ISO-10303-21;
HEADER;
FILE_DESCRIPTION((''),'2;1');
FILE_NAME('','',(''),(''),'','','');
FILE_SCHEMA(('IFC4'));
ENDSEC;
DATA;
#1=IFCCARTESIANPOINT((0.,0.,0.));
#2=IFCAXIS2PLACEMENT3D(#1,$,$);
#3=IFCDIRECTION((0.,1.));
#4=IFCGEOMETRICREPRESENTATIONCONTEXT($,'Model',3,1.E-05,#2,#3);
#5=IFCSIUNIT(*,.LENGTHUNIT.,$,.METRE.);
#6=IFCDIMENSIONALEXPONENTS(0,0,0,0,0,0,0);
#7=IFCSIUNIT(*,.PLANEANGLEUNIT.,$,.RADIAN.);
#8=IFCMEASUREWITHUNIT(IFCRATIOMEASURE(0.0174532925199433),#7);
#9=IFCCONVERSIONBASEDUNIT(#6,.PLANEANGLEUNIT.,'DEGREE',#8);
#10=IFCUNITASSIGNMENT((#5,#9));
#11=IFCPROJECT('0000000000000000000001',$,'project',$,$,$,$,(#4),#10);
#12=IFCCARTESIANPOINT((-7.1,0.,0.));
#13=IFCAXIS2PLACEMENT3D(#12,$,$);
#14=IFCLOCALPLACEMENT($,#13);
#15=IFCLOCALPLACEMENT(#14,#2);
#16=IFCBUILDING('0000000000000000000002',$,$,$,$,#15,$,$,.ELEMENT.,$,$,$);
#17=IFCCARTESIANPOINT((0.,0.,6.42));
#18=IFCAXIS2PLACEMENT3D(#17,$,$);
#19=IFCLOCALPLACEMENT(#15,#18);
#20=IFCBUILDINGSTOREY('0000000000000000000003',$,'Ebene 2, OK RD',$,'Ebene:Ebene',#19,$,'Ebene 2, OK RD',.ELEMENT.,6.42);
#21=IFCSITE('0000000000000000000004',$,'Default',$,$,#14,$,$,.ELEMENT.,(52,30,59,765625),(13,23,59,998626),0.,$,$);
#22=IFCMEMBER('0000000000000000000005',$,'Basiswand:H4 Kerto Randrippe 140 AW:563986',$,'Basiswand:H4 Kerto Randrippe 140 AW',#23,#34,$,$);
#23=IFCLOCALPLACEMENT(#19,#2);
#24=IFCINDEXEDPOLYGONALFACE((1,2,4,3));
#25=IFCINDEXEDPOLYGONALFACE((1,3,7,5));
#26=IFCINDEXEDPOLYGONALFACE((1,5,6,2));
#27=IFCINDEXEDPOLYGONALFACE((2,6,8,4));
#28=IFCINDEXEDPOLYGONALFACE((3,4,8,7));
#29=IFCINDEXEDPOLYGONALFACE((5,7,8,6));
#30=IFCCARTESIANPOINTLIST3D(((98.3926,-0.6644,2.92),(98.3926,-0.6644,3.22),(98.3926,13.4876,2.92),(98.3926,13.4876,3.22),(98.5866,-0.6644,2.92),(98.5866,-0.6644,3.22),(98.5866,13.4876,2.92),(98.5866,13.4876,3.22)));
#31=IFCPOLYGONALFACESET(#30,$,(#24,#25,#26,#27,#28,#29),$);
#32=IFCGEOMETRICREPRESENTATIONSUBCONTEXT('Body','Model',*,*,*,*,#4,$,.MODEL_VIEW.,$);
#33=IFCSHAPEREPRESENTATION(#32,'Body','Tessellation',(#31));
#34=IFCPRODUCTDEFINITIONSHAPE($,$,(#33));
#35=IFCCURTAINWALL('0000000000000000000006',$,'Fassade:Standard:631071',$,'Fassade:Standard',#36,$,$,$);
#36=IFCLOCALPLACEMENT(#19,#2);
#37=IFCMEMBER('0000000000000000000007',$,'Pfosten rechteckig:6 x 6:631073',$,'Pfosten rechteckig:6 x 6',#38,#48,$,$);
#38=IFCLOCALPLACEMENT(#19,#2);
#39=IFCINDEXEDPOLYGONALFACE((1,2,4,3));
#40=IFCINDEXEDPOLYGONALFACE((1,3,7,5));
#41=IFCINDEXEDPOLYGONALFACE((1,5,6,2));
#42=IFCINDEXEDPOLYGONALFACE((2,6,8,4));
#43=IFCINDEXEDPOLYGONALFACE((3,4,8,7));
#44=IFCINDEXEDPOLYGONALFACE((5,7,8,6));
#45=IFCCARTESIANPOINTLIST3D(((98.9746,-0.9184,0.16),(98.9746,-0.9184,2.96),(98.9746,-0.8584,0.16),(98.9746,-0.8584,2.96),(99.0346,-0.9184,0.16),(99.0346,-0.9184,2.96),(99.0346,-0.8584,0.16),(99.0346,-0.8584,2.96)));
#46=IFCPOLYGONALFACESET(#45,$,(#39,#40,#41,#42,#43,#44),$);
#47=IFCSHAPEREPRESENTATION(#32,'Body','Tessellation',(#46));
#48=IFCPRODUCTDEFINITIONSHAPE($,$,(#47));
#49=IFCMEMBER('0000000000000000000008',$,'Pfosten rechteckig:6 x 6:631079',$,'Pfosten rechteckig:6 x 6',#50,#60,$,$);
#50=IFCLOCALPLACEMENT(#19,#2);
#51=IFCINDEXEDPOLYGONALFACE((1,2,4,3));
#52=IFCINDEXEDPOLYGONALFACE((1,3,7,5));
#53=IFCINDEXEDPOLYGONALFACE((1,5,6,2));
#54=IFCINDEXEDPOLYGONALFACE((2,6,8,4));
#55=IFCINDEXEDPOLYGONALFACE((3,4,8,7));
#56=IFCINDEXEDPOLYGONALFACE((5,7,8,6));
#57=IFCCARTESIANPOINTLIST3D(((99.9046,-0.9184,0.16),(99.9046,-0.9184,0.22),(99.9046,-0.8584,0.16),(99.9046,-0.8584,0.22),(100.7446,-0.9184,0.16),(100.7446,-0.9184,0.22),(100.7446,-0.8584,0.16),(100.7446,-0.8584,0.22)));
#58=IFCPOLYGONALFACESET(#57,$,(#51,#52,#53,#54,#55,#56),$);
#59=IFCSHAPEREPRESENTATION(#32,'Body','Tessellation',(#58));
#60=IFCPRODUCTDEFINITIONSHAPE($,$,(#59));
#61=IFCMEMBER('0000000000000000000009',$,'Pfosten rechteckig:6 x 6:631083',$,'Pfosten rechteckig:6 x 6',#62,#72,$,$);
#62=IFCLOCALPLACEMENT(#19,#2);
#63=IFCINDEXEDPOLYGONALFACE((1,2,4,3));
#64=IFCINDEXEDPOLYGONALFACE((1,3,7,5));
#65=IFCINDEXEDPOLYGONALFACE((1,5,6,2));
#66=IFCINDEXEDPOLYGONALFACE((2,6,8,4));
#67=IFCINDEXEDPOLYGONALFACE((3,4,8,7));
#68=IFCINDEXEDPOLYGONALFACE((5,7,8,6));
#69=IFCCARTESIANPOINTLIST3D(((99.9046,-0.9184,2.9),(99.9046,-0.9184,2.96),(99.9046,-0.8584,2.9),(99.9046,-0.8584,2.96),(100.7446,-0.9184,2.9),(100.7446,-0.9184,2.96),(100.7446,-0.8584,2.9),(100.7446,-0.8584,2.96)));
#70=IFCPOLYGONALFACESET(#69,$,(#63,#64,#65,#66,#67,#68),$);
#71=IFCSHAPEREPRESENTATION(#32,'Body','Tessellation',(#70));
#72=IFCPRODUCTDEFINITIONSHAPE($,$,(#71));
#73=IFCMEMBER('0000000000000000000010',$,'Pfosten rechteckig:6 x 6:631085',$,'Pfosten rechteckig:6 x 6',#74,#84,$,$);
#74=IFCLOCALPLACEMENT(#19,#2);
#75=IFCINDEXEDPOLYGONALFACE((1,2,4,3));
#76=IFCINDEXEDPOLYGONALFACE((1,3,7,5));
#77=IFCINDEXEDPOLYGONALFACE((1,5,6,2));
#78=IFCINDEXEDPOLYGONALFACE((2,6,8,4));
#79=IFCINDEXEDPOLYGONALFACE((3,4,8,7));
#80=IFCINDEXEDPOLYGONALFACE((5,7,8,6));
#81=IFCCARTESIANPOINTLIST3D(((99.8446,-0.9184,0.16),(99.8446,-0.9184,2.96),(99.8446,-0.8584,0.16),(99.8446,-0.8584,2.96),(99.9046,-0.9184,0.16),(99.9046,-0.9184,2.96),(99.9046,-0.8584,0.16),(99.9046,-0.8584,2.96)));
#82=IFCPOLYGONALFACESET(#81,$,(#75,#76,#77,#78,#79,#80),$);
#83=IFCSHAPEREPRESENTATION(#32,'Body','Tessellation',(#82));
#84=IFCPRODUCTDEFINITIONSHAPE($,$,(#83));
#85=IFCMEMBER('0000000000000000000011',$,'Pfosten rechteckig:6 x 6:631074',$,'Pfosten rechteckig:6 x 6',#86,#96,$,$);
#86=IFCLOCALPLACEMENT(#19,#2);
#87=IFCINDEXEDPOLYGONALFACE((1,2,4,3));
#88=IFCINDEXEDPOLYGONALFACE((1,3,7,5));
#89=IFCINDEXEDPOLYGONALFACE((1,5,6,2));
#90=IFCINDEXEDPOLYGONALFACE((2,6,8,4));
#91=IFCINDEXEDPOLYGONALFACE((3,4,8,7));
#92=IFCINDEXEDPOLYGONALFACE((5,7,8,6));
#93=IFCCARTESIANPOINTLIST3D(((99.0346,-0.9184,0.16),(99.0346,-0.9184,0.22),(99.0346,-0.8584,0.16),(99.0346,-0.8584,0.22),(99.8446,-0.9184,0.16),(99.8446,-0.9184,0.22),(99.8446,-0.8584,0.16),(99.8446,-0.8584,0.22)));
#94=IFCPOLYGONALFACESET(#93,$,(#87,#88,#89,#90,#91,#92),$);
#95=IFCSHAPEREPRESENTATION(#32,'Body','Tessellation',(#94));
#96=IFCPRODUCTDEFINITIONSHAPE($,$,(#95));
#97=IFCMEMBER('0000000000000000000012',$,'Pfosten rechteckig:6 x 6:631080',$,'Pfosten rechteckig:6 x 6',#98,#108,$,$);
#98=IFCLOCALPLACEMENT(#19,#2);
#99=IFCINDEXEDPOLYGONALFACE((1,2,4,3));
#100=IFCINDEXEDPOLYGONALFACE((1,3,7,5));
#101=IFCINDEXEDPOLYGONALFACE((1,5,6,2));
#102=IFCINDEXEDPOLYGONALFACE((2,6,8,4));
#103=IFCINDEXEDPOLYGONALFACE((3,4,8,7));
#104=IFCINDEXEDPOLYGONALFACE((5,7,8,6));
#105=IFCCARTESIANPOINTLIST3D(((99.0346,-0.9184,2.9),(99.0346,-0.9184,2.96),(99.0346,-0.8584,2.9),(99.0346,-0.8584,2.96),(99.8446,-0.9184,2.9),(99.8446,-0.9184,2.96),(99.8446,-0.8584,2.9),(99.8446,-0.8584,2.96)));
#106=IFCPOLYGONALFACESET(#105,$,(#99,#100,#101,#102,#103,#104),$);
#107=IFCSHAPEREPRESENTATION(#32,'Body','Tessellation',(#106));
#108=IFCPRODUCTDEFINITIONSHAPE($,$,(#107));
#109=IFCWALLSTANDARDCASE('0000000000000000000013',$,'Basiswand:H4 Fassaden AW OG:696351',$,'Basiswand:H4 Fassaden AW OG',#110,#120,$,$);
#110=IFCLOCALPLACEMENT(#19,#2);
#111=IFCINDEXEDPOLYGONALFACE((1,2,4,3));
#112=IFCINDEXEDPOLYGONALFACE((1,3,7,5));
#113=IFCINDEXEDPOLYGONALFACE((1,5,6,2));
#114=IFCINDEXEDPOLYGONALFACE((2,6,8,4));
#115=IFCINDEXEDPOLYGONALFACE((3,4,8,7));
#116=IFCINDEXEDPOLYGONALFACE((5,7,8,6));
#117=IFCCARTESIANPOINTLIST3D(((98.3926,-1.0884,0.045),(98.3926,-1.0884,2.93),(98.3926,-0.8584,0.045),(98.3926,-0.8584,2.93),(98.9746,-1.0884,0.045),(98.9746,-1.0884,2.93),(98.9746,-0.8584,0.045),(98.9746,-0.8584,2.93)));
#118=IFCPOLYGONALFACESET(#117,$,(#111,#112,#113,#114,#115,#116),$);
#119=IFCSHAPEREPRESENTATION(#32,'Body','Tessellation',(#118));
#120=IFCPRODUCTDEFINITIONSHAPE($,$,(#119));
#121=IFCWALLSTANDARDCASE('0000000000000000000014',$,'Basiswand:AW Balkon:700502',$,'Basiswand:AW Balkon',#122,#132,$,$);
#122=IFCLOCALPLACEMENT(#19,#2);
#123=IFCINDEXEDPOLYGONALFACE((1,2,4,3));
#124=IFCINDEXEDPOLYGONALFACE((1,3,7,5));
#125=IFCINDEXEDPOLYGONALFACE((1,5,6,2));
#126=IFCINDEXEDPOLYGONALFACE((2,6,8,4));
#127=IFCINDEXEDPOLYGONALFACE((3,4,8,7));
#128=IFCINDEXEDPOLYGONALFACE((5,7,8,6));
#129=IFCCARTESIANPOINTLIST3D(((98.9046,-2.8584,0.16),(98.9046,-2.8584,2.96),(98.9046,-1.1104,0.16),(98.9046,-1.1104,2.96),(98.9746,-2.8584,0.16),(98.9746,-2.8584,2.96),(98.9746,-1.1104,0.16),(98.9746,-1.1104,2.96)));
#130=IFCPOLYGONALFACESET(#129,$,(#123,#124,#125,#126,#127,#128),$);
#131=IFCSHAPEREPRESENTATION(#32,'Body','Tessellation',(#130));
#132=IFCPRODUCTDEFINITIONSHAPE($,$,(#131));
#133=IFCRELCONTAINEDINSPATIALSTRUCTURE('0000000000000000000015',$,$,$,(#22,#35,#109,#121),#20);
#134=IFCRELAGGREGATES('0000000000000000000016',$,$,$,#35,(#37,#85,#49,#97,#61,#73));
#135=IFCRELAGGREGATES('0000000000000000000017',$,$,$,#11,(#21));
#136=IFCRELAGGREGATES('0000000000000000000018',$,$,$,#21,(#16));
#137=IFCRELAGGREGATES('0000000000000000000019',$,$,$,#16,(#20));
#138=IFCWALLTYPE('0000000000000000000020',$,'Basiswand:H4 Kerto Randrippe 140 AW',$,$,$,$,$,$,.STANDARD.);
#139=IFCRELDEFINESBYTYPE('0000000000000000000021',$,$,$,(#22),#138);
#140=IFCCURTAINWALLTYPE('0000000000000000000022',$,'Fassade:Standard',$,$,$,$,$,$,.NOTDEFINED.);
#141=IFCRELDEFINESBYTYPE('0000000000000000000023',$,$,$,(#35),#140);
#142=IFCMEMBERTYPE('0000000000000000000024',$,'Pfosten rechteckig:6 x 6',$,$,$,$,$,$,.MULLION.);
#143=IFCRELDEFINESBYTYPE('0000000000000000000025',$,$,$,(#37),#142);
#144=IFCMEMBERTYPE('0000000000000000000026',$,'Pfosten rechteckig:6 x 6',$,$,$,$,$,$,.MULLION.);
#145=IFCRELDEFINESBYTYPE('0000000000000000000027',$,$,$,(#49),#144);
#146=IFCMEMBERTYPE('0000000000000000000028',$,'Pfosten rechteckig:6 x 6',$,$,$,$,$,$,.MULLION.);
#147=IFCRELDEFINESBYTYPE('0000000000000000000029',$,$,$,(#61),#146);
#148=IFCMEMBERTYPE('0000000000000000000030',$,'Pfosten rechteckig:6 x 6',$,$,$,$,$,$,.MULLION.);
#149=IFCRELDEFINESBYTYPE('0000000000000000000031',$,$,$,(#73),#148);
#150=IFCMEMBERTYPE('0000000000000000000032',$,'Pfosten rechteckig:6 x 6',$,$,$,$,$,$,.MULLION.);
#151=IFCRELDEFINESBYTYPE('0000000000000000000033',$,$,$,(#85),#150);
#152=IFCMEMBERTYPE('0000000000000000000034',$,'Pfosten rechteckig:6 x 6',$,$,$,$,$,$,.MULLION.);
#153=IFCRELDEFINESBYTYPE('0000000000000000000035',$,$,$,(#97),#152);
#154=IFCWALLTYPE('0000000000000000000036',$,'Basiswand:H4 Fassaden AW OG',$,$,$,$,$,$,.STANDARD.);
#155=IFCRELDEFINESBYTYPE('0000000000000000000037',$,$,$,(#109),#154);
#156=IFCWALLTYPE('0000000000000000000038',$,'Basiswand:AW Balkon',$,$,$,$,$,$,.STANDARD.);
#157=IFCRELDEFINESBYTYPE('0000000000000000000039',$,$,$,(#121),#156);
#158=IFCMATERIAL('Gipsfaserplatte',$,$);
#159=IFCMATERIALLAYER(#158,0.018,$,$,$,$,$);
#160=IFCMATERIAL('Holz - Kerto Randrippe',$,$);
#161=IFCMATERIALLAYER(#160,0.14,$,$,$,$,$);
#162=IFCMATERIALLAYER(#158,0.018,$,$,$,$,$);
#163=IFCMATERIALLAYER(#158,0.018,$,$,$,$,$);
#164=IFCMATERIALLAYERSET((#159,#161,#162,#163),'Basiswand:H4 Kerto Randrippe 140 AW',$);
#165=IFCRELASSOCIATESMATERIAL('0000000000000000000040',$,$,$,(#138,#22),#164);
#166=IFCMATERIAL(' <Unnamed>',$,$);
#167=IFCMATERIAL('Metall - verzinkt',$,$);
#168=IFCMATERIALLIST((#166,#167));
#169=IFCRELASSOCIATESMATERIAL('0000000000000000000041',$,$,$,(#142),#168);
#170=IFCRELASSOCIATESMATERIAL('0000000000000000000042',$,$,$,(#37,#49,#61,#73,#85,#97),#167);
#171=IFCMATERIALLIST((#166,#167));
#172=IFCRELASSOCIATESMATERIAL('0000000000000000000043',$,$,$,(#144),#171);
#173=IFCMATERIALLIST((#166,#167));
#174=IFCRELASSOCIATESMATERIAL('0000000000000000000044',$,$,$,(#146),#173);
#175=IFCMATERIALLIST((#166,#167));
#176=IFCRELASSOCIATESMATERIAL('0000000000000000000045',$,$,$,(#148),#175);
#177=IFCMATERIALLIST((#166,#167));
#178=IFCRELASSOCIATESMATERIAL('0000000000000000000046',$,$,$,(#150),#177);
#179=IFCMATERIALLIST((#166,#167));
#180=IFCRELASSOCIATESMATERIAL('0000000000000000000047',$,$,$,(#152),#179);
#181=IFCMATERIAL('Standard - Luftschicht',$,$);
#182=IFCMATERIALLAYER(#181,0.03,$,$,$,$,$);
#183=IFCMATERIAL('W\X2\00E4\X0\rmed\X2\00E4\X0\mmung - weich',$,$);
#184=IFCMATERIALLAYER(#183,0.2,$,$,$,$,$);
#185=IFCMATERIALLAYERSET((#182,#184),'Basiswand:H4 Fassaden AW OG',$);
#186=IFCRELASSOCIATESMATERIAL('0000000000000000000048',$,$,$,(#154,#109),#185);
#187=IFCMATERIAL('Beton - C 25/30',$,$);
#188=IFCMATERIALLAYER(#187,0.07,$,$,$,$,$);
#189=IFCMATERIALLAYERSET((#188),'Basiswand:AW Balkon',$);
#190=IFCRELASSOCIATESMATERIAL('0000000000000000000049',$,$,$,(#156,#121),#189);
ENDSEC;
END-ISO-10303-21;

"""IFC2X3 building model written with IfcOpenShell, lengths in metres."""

from ifc_helpers import new_model, entity, si_unit, converted_unit, direction, frame, frame_2d, origin, origin_2d_with_axis, place, context, subcontext, project, spatial, rectangle, extrude, source, transform, mapped, material, material_list, layer, layer_set, layer_usage, type_object, type_shapes, element, aggregate, save


model = new_model("IFC2X3")

# Units and contexts
model_context = context("Model", 3, precision=1e-05, world=origin(), true_north=direction((0.0, 1.0)))
body_context = subcontext(model_context, "Body", "Model", "MODEL_VIEW")
ifc_project = project(units=[si_unit("LENGTHUNIT", "METRE"), converted_unit("PLANEANGLEUNIT", "DEGREE", entity("IfcRatioMeasure", 0.0174532925199433), si_unit("PLANEANGLEUNIT", "RADIAN"), dimensions=[0, 0, 0, 0, 0, 0, 0])], contexts=[model_context])

# Site, building, storey
site_placement = place(None, frame((-7.1, 0.0, 0.0)))
site = spatial("IfcSite", under=ifc_project, at=site_placement, Name="Default", CompositionType="ELEMENT", RefLatitude=(52, 30, 59, 765625), RefLongitude=(13, 23, 59, 998626), RefElevation=0.0)
building_placement = place(site_placement, origin())
building = spatial("IfcBuilding", under=site, at=building_placement, CompositionType="ELEMENT")
storey_placement = place(building_placement, frame((0.0, 0.0, 6.42)))
storey = spatial("IfcBuildingStorey", under=building, at=storey_placement, Name="Ebene 2, OK RD", ObjectType="Ebene:Ebene", LongName="Ebene 2, OK RD", CompositionType="ELEMENT", Elevation=6.42)

# Member
ifc_material_1 = material(Name="Gipsfaserplatte")
ifc_layer_1 = layer(ifc_material_1, 0.018)
ifc_material_2 = material(Name="Holz - Kerto Randrippe")
ifc_layer_2 = layer(ifc_material_2, 0.14)
ifc_layer_3 = layer(ifc_material_1, 0.018)
ifc_layer_4 = layer(ifc_material_1, 0.018)
ifc_layer_set_1 = layer_set([ifc_layer_1, ifc_layer_2, ifc_layer_3, ifc_layer_4], Name="Basiswand:H4 Kerto Randrippe 140 AW")
ifc_layer_usage_1 = layer_usage(ifc_layer_set_1, "AXIS2", "NEGATIVE", 0.097)
wall_type_1 = type_object("IfcWallType", Name="Basiswand:H4 Kerto Randrippe 140 AW", PredefinedType="STANDARD", material=ifc_layer_set_1)
member_1_placement = place(storey_placement, frame((98.4896, -0.6644, 2.92), z_axis=(0.0, 0.0, 1.0), x_axis=(0.0, 1.0, 0.0)))
element("IfcMember", 1, at=member_1_placement, inside=storey, type_object=wall_type_1, material=ifc_layer_usage_1, Name="Basiswand:H4 Kerto Randrippe 140 AW:563986", ObjectType="Basiswand:H4 Kerto Randrippe 140 AW", context=body_context, shape_type="SweptSolid", body=[
    extrude(rectangle(XDim=14.152, YDim=0.194, at=frame_2d((7.076, 0.0), x_axis=(-1.0, 0.0))), origin(), (0.0, 0.0, 1.0), 0.3),
])

# Curtain wall, members
curtain_wall_type = type_object("IfcCurtainWallType", Name="Fassade:Standard", PredefinedType="NOTDEFINED")
curtain_wall_placement = place(storey_placement, frame((0.0, 0.0, -6.42)))
curtain_wall = element("IfcCurtainWall", 2, at=curtain_wall_placement, inside=storey, type_object=curtain_wall_type, Name="Fassade:Standard:631071", ObjectType="Fassade:Standard")
ifc_material_3 = material(Name="Metall - verzinkt")
ifc_material_4 = material(Name=" <Unnamed>")
ifc_material_list_1 = material_list([ifc_material_4, ifc_material_3])
member_type_1 = type_object("IfcMemberType", Name="Pfosten rechteckig:6 x 6", PredefinedType="MULLION", material=ifc_material_list_1)
shared_shape_1 = source(origin(), body_context, "Body", "SweptSolid", [
    extrude(rectangle(XDim=0.06, YDim=0.06, at=origin_2d_with_axis()), frame((-0.03, 0.0, -2.8), z_axis=(0.0, 0.0, 1.0), x_axis=(0.0, -1.0, 0.0)), (0.0, 0.0, 1.0), 2.8),
])
type_shapes(member_type_1, [shared_shape_1])
placement = place(building_placement, frame((0.0, 0.0, 3.26)))
member_2_placement = place(placement, frame((98.9746, -0.8884, 6.12), z_axis=(0.0, 0.0, 1.0), x_axis=(-1.0, 0.0, 0.0)))
member_2 = element("IfcMember", 3, at=member_2_placement, type_object=member_type_1, material=ifc_material_3, Name="Pfosten rechteckig:6 x 6:631073", ObjectType="Pfosten rechteckig:6 x 6", context=body_context, shape_type="MappedRepresentation", body=[
    mapped(shared_shape_1, transform((0.0, 0.0, 0.0), scale=1.0)),
])
ifc_material_list_2 = material_list([ifc_material_4, ifc_material_3])
member_type_2 = type_object("IfcMemberType", Name="Pfosten rechteckig:6 x 6", PredefinedType="MULLION", material=ifc_material_list_2)
shared_shape_2 = source(origin(), body_context, "Body", "SweptSolid", [
    extrude(rectangle(XDim=0.06, YDim=0.06, at=origin_2d_with_axis()), frame((-0.03, 0.0, -0.84), z_axis=(0.0, 0.0, 1.0), x_axis=(0.0, -1.0, 0.0)), (0.0, 0.0, 1.0), 0.84),
])
type_shapes(member_type_2, [shared_shape_2])
member_3_placement = place(placement, frame((99.9046, -0.8884, 3.32), z_axis=(-1.0, 0.0, 0.0), x_axis=(0.0, 0.0, -1.0)))
member_3 = element("IfcMember", 4, at=member_3_placement, type_object=member_type_2, material=ifc_material_3, Name="Pfosten rechteckig:6 x 6:631079", ObjectType="Pfosten rechteckig:6 x 6", context=body_context, shape_type="MappedRepresentation", body=[
    mapped(shared_shape_2, transform((0.0, 0.0, 0.0), scale=1.0)),
])
ifc_material_list_3 = material_list([ifc_material_4, ifc_material_3])
member_type_3 = type_object("IfcMemberType", Name="Pfosten rechteckig:6 x 6", PredefinedType="MULLION", material=ifc_material_list_3)
shared_shape_3 = source(origin(), body_context, "Body", "SweptSolid", [
    extrude(rectangle(XDim=0.06, YDim=0.06, at=origin_2d_with_axis()), frame((-0.03, 0.0, -0.84), z_axis=(0.0, 0.0, 1.0), x_axis=(0.0, -1.0, 0.0)), (0.0, 0.0, 1.0), 0.84),
])
type_shapes(member_type_3, [shared_shape_3])
member_4_placement = place(placement, frame((100.7446, -0.8884, 6.12), z_axis=(1.0, 0.0, 0.0), x_axis=(0.0, 0.0, 1.0)))
member_4 = element("IfcMember", 5, at=member_4_placement, type_object=member_type_3, material=ifc_material_3, Name="Pfosten rechteckig:6 x 6:631083", ObjectType="Pfosten rechteckig:6 x 6", context=body_context, shape_type="MappedRepresentation", body=[
    mapped(shared_shape_3, transform((0.0, 0.0, 0.0), scale=1.0)),
])
ifc_material_list_4 = material_list([ifc_material_4, ifc_material_3])
member_type_4 = type_object("IfcMemberType", Name="Pfosten rechteckig:6 x 6", PredefinedType="MULLION", material=ifc_material_list_4)
shared_shape_4 = source(origin(), body_context, "Body", "SweptSolid", [
    extrude(rectangle(XDim=0.06, YDim=0.06, at=origin_2d_with_axis()), frame((0.0, 0.0, -2.8), z_axis=(0.0, 0.0, 1.0), x_axis=(0.0, -1.0, 0.0)), (0.0, 0.0, 1.0), 2.8),
])
type_shapes(member_type_4, [shared_shape_4])
member_5_placement = place(placement, frame((99.8746, -0.8884, 3.32), z_axis=(0.0, 0.0, -1.0), x_axis=(1.0, 0.0, 0.0)))
member_5 = element("IfcMember", 6, at=member_5_placement, type_object=member_type_4, material=ifc_material_3, Name="Pfosten rechteckig:6 x 6:631085", ObjectType="Pfosten rechteckig:6 x 6", context=body_context, shape_type="MappedRepresentation", body=[
    mapped(shared_shape_4, transform((0.0, 0.0, 0.0), scale=1.0)),
])
ifc_material_list_5 = material_list([ifc_material_4, ifc_material_3])
member_type_5 = type_object("IfcMemberType", Name="Pfosten rechteckig:6 x 6", PredefinedType="MULLION", material=ifc_material_list_5)
shared_shape_5 = source(origin(), body_context, "Body", "SweptSolid", [
    extrude(rectangle(XDim=0.06, YDim=0.06, at=origin_2d_with_axis()), frame((-0.03, 0.0, -0.81), z_axis=(0.0, 0.0, 1.0), x_axis=(0.0, -1.0, 0.0)), (0.0, 0.0, 1.0), 0.81),
])
type_shapes(member_type_5, [shared_shape_5])
member_6_placement = place(placement, frame((99.0346, -0.8884, 3.32), z_axis=(-1.0, 0.0, 0.0), x_axis=(0.0, 0.0, -1.0)))
member_6 = element("IfcMember", 7, at=member_6_placement, type_object=member_type_5, material=ifc_material_3, Name="Pfosten rechteckig:6 x 6:631074", ObjectType="Pfosten rechteckig:6 x 6", context=body_context, shape_type="MappedRepresentation", body=[
    mapped(shared_shape_5, transform((0.0, 0.0, 0.0), scale=1.0)),
])
ifc_material_list_6 = material_list([ifc_material_4, ifc_material_3])
member_type_6 = type_object("IfcMemberType", Name="Pfosten rechteckig:6 x 6", PredefinedType="MULLION", material=ifc_material_list_6)
shared_shape_6 = source(origin(), body_context, "Body", "SweptSolid", [
    extrude(rectangle(XDim=0.06, YDim=0.06, at=origin_2d_with_axis()), frame((-0.03, 0.0, -0.81), z_axis=(0.0, 0.0, 1.0), x_axis=(0.0, -1.0, 0.0)), (0.0, 0.0, 1.0), 0.81),
])
type_shapes(member_type_6, [shared_shape_6])
member_7_placement = place(placement, frame((99.8446, -0.8884, 6.12), z_axis=(1.0, 0.0, 0.0), x_axis=(0.0, 0.0, 1.0)))
member_7 = element("IfcMember", 8, at=member_7_placement, type_object=member_type_6, material=ifc_material_3, Name="Pfosten rechteckig:6 x 6:631080", ObjectType="Pfosten rechteckig:6 x 6", context=body_context, shape_type="MappedRepresentation", body=[
    mapped(shared_shape_6, transform((0.0, 0.0, 0.0), scale=1.0)),
])

# Shared definitions
ifc_material_5 = material(Name="Standard - Luftschicht")
ifc_material_6 = material(Name="Wärmedämmung - weich")

aggregate(curtain_wall, [member_2, member_6, member_3, member_7, member_4, member_5])

# Walls
ifc_layer_5 = layer(ifc_material_5, 0.03)
ifc_layer_6 = layer(ifc_material_6, 0.2)
ifc_layer_set_2 = layer_set([ifc_layer_5, ifc_layer_6], Name="Basiswand:H4 Fassaden AW OG")
ifc_layer_usage_2 = layer_usage(ifc_layer_set_2, "AXIS2", "NEGATIVE", 0.115)
wall_type_2 = type_object("IfcWallType", Name="Basiswand:H4 Fassaden AW OG", PredefinedType="STANDARD", material=ifc_layer_set_2)
wall_1_placement = place(storey_placement, frame((98.9746, -0.9734, 0.045), z_axis=(0.0, 0.0, 1.0), x_axis=(-1.0, 0.0, 0.0)))
element("IfcWallStandardCase", 9, at=wall_1_placement, inside=storey, type_object=wall_type_2, material=ifc_layer_usage_2, Name="Basiswand:H4 Fassaden AW OG:696351", ObjectType="Basiswand:H4 Fassaden AW OG", context=body_context, shape_type="SweptSolid", body=[
    extrude(rectangle(XDim=0.582, YDim=0.23, at=frame_2d((0.291, 0.0), x_axis=(-1.0, 0.0))), origin(), (0.0, 0.0, 1.0), 2.885),
])
ifc_material_7 = material(Name="Beton - C 25/30")
ifc_layer_7 = layer(ifc_material_7, 0.07)
ifc_layer_set_3 = layer_set([ifc_layer_7], Name="Basiswand:AW Balkon")
ifc_layer_usage_3 = layer_usage(ifc_layer_set_3, "AXIS2", "NEGATIVE", 0.035)
wall_type_3 = type_object("IfcWallType", Name="Basiswand:AW Balkon", PredefinedType="STANDARD", material=ifc_layer_set_3)
wall_2_placement = place(storey_placement, frame((98.9396, -2.8584, 0.16), z_axis=(0.0, 0.0, 1.0), x_axis=(0.0, 1.0, 0.0)))
element("IfcWallStandardCase", 10, at=wall_2_placement, inside=storey, type_object=wall_type_3, material=ifc_layer_usage_3, Name="Basiswand:AW Balkon:700502", ObjectType="Basiswand:AW Balkon", context=body_context, shape_type="SweptSolid", body=[
    extrude(rectangle(XDim=1.748, YDim=0.07, at=frame_2d((0.874, 0.0), x_axis=(-1.0, 0.0))), origin(), (0.0, 0.0, 1.0), 2.8),
])

save(model, "model.ifc")
